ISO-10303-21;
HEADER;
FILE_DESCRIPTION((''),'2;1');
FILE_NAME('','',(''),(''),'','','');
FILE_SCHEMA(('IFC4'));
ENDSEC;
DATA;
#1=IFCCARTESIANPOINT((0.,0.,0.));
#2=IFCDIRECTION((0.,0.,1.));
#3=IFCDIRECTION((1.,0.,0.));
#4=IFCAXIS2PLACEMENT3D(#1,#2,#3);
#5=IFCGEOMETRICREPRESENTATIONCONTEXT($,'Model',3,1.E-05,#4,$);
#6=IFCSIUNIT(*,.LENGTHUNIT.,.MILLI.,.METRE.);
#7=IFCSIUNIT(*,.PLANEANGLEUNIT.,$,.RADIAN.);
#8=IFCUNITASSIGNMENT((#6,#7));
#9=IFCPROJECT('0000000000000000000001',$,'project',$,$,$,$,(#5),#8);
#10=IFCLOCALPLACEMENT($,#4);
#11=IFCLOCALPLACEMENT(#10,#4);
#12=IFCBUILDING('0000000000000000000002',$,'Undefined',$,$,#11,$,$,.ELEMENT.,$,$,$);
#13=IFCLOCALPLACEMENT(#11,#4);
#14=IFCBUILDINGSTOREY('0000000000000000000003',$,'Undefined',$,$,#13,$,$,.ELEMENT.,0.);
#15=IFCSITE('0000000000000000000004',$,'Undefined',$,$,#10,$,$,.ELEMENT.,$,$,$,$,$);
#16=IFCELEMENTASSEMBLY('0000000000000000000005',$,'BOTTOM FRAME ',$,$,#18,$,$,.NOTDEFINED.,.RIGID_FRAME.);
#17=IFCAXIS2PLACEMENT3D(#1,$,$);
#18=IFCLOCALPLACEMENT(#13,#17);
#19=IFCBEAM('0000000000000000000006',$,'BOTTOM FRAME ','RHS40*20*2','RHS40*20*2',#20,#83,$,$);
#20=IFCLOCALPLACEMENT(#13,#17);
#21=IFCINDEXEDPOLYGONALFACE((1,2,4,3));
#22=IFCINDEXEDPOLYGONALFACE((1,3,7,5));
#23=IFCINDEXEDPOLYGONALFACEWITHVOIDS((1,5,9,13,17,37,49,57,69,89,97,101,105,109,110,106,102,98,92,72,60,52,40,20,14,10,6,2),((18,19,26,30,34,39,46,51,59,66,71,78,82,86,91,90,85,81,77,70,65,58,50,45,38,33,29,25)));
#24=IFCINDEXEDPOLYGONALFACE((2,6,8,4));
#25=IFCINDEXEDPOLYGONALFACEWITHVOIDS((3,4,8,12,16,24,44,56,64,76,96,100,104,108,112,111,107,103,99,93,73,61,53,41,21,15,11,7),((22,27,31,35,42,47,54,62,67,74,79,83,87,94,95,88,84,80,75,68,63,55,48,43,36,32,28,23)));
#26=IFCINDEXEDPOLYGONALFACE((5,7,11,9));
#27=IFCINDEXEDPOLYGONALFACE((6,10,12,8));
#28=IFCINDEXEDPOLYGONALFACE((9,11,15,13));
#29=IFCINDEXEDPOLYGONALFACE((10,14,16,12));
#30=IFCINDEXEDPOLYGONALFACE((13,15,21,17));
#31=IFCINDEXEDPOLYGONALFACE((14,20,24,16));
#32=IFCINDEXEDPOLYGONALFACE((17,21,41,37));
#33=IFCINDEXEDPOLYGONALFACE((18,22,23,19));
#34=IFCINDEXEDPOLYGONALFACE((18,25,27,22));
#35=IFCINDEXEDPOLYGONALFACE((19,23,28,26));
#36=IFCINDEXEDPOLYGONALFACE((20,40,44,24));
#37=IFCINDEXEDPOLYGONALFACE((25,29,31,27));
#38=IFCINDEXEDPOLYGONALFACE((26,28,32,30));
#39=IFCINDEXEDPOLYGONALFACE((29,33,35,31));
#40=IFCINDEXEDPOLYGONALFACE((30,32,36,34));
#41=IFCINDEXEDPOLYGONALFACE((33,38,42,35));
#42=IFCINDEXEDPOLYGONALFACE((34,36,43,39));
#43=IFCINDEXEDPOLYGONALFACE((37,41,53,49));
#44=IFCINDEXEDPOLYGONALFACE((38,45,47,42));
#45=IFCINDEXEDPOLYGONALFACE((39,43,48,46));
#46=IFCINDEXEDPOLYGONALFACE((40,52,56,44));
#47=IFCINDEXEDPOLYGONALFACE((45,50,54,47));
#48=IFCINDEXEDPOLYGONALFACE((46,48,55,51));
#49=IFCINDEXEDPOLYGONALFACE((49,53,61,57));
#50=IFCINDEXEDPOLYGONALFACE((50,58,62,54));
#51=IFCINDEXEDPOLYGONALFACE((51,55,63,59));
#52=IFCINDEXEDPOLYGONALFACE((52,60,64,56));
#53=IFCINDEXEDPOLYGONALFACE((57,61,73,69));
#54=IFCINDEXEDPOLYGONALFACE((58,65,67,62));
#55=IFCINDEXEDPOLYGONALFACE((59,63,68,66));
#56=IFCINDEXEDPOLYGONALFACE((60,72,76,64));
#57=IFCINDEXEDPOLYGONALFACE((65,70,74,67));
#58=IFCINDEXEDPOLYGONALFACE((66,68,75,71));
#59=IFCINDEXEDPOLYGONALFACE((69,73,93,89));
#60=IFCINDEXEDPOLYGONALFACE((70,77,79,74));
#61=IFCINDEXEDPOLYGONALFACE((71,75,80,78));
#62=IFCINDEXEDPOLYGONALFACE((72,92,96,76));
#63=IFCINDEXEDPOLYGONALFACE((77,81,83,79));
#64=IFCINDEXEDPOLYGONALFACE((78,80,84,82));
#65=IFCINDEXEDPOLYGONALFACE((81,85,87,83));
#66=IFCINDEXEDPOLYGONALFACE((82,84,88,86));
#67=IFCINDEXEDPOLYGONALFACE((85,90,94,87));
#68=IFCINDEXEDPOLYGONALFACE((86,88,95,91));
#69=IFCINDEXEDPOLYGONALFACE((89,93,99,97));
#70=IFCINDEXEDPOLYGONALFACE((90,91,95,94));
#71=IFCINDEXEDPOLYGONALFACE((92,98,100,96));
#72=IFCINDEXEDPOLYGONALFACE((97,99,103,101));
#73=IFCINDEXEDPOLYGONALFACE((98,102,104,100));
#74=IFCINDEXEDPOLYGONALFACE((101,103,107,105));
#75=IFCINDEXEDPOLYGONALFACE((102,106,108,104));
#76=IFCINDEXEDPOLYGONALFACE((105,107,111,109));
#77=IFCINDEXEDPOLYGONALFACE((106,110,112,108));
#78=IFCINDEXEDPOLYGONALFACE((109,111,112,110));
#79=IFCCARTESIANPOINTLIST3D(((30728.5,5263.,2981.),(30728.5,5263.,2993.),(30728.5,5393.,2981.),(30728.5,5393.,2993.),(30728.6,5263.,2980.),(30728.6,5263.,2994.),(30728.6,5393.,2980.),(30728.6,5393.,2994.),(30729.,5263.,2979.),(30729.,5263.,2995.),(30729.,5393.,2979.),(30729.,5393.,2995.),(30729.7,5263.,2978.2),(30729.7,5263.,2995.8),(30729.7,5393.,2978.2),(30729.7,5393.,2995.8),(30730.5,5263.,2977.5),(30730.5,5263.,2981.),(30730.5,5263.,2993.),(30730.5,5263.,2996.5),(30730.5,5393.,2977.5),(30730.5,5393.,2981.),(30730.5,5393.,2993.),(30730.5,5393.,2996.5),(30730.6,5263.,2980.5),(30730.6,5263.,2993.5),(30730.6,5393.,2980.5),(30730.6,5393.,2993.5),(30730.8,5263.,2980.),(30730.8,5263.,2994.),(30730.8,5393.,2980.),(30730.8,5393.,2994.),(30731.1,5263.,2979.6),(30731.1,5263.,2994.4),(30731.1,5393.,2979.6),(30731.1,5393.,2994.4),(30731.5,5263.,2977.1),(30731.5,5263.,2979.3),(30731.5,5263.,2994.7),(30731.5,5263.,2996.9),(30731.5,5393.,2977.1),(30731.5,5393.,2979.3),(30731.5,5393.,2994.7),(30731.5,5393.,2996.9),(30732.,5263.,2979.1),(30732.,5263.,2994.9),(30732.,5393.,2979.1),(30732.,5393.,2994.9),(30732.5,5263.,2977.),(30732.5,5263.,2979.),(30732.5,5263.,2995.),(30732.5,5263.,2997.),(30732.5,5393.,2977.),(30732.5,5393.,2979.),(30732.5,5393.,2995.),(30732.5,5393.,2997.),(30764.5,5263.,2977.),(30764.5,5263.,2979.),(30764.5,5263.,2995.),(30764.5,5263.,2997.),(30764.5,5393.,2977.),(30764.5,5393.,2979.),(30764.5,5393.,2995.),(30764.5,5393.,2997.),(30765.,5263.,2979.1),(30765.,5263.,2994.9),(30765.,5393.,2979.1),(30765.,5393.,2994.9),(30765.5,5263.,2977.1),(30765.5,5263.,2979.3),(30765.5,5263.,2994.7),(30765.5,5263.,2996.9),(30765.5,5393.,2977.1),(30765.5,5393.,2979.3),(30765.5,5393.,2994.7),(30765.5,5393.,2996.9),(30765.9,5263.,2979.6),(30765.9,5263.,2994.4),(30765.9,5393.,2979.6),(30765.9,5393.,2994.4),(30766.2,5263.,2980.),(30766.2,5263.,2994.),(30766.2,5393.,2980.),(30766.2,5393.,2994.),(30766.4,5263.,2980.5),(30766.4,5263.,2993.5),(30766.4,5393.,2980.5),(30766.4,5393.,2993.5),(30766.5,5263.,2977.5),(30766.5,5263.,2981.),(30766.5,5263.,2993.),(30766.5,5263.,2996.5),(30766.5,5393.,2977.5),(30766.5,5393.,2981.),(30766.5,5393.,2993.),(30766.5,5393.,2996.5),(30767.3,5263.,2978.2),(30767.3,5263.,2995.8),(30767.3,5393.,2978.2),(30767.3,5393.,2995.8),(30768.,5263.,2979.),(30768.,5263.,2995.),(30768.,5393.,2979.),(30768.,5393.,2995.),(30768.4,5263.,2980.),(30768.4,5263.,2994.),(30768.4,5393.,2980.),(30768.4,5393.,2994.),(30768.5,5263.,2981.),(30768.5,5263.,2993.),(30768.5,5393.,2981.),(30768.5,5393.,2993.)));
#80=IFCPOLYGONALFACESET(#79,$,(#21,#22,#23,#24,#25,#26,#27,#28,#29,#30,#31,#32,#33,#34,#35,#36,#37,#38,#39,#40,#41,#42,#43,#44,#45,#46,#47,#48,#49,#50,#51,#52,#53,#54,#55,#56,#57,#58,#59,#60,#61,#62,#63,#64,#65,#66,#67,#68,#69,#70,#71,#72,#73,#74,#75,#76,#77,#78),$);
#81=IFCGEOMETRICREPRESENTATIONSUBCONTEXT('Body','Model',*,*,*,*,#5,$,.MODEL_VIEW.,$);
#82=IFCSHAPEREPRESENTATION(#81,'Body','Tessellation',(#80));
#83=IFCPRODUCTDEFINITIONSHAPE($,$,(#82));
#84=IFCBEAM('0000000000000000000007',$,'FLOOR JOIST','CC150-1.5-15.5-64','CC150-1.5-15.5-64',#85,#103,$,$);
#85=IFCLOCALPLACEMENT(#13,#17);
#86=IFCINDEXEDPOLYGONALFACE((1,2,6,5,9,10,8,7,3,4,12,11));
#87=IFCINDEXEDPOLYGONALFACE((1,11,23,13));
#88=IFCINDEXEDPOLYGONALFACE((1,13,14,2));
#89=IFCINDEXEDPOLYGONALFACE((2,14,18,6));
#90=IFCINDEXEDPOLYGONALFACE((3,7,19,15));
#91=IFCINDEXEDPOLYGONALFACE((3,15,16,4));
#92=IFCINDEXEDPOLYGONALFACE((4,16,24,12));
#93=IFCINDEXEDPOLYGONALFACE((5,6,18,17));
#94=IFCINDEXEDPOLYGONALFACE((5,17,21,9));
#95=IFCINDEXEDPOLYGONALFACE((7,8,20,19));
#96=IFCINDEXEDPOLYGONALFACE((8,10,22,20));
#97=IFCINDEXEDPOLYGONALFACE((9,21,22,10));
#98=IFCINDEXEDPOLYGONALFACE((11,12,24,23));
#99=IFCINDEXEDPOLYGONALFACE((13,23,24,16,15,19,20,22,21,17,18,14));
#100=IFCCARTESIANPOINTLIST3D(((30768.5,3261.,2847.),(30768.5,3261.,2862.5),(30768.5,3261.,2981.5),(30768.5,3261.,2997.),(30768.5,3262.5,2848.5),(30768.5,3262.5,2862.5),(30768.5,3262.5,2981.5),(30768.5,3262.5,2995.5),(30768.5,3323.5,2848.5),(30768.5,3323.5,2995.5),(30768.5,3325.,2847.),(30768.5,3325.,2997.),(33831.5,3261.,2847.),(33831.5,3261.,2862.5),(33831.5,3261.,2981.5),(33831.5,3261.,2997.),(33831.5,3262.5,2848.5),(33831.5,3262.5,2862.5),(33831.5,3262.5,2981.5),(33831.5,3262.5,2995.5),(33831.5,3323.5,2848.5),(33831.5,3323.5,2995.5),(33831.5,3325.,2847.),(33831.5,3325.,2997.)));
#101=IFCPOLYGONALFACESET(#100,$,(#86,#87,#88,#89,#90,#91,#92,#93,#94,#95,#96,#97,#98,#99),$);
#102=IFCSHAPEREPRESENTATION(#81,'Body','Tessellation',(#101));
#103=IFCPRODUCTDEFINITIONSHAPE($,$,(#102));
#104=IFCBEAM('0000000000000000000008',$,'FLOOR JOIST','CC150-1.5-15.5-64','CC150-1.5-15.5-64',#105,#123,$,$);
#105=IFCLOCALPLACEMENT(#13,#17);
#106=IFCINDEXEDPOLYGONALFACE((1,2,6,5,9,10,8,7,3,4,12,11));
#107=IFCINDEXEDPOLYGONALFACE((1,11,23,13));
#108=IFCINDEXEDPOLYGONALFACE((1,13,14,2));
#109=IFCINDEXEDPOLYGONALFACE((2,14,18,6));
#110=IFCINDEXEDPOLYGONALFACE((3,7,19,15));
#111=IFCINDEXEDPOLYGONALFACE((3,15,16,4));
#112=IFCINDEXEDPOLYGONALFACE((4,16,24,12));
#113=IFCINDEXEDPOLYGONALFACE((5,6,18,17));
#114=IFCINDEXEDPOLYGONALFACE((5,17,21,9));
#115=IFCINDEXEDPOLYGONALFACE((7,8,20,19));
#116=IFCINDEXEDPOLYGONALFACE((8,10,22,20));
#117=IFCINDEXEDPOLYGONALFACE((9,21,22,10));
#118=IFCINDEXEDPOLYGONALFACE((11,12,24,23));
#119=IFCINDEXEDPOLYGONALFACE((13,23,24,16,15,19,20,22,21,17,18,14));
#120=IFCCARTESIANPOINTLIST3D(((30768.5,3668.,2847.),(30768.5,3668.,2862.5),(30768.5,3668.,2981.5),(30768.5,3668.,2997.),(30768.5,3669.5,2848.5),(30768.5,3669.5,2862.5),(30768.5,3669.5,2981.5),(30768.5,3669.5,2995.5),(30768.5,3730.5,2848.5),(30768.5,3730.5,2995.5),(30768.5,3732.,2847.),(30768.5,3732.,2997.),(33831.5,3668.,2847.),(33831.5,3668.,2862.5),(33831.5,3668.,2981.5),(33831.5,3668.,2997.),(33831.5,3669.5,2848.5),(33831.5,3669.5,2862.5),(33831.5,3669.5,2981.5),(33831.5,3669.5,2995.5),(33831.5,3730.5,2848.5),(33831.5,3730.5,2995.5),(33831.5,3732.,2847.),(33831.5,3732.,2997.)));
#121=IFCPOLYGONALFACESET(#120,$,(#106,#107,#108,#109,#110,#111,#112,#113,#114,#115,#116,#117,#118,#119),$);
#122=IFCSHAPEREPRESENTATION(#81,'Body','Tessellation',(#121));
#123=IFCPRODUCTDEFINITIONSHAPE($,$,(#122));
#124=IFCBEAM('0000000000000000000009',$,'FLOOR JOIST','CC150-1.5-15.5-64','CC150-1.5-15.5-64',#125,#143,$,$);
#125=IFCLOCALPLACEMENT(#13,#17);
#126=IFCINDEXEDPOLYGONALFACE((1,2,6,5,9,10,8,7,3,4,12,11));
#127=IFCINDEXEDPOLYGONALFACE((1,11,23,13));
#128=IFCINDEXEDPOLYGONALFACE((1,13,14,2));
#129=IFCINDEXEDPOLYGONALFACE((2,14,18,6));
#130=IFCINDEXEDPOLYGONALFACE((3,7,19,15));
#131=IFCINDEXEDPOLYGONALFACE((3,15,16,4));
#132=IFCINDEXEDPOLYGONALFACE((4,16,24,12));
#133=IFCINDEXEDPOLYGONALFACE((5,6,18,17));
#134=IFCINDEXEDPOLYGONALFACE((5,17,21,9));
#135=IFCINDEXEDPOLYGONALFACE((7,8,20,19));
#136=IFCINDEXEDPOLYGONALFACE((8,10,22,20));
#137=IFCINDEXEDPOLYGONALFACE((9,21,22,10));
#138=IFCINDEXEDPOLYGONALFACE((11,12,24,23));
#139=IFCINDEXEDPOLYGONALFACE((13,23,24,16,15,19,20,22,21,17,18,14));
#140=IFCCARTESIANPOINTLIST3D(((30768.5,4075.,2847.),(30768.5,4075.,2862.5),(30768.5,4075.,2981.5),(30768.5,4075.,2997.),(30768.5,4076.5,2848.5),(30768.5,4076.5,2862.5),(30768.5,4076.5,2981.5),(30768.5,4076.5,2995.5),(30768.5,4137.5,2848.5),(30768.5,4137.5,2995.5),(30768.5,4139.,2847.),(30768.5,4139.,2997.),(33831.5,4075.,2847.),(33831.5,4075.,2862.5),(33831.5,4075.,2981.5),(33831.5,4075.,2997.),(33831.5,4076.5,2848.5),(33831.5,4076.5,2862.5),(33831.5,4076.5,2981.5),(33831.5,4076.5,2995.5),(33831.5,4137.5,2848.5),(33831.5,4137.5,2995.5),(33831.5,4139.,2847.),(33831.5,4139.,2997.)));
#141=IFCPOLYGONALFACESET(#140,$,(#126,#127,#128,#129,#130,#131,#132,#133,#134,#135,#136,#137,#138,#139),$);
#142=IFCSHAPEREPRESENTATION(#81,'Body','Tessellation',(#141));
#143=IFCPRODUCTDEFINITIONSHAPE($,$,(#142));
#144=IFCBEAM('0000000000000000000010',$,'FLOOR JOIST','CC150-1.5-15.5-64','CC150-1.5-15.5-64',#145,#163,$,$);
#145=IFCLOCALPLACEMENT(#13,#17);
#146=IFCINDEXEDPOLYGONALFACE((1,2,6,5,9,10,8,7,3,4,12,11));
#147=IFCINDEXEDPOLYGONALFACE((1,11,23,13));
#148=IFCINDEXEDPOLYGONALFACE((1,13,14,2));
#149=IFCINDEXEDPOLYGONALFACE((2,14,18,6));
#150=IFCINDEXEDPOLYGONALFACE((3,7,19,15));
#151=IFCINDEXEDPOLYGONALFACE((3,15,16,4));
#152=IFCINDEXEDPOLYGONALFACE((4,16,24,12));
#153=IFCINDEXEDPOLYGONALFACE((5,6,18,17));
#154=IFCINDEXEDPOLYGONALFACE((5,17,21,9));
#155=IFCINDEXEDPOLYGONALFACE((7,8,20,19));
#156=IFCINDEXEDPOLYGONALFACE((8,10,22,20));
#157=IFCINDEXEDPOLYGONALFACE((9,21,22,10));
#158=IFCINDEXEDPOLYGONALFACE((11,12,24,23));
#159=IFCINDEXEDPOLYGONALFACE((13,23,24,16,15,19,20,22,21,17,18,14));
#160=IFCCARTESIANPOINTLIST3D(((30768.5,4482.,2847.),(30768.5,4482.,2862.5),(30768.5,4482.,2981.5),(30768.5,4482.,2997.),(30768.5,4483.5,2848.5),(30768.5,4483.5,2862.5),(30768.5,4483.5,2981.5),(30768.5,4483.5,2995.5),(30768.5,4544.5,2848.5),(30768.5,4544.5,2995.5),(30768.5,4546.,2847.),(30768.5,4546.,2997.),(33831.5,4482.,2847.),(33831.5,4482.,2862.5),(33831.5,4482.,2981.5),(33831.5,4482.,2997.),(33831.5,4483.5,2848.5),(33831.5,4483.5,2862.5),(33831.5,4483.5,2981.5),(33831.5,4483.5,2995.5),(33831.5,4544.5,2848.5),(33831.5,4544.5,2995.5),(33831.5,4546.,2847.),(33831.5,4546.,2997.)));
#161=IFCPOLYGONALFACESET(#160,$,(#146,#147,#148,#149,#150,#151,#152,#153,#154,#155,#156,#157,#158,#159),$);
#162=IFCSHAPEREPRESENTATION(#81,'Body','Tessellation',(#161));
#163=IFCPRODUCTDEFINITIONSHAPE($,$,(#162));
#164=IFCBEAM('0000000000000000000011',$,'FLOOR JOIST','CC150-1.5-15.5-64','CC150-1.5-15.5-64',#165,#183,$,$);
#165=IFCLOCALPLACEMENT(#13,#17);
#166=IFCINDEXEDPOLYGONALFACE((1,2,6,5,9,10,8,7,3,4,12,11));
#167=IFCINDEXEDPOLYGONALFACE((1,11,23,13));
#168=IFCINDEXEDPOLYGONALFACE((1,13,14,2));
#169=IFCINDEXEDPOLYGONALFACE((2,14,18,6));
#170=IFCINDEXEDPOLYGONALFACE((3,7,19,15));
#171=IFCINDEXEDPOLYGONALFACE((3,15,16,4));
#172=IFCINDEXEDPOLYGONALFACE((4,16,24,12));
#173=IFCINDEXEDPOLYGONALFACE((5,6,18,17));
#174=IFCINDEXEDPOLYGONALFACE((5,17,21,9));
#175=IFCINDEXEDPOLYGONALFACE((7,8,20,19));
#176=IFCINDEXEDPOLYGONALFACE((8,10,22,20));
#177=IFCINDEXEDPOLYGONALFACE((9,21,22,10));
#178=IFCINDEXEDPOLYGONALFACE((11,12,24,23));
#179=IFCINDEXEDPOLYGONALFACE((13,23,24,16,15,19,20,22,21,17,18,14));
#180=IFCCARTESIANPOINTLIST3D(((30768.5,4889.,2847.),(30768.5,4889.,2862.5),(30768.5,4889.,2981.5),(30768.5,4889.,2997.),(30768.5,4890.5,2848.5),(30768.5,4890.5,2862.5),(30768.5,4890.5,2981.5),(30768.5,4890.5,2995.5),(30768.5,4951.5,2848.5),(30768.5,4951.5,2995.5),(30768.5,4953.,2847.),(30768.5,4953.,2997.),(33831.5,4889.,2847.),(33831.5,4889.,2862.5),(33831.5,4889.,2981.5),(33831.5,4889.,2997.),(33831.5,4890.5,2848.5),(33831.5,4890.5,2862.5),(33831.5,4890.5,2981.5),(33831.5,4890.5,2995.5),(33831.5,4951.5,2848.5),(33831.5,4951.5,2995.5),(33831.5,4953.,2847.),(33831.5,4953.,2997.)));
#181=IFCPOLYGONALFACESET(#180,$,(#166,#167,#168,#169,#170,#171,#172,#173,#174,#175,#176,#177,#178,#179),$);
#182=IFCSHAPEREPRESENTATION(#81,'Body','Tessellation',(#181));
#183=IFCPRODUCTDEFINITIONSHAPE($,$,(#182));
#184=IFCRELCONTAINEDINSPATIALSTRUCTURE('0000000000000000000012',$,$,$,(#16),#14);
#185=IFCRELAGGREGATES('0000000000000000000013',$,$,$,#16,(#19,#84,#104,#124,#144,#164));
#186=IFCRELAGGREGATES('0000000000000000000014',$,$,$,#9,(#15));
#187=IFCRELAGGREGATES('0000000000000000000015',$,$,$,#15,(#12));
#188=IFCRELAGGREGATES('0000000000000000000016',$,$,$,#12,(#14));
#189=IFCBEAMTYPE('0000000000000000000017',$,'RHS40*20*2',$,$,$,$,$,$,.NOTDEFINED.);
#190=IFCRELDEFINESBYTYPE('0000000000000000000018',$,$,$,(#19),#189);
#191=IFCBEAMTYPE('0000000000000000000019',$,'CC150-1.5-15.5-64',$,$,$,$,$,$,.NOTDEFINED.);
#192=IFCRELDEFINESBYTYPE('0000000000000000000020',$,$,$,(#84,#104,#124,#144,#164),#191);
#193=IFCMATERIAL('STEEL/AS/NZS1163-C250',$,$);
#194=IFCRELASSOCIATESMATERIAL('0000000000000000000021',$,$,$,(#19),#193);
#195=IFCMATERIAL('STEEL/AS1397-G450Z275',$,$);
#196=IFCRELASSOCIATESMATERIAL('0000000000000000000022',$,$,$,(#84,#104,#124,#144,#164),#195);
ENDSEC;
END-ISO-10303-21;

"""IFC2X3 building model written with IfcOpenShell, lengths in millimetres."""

from ifc_helpers import new_model, si_unit, frame, origin_with_axes, origin_2d_with_axis, place, context, subcontext, project, spatial, hollow_rectangle, c_section, extrude, material, type_object, element, aggregate, save


model = new_model("IFC2X3")

# Units and contexts
model_context = context("Model", 3, precision=1e-05, world=origin_with_axes())
body_context = subcontext(model_context, "Body", "Model", "MODEL_VIEW")
ifc_project = project(units=[si_unit("LENGTHUNIT", "METRE", prefix="MILLI"), si_unit("PLANEANGLEUNIT", "RADIAN")], contexts=[model_context])

# Site, building, storey
site_placement = place(None, origin_with_axes())
site = spatial("IfcSite", under=ifc_project, at=site_placement, Name="Undefined", CompositionType="ELEMENT")
building_placement = place(site_placement, origin_with_axes())
building = spatial("IfcBuilding", under=site, at=building_placement, Name="Undefined", CompositionType="ELEMENT")
storey_placement = place(building_placement, origin_with_axes())
storey = spatial("IfcBuildingStorey", under=building, at=storey_placement, Name="Undefined", CompositionType="ELEMENT", Elevation=0.0)

# Element assembly, beams
assembly_1_placement = place(storey_placement, origin_with_axes())
assembly_1 = element("IfcElementAssembly", 1, at=assembly_1_placement, inside=storey, Name="BOTTOM FRAME ", AssemblyPlace="NOTDEFINED", PredefinedType="RIGID_FRAME")
ifc_material_1 = material(Name="STEEL/AS/NZS1163-C250")
beam_type_1 = type_object("IfcBeamType", Name="RHS40*20*2", PredefinedType="NOTDEFINED")
beam_1_placement = place(assembly_1_placement, frame((30748.5, 5393.0, 2987.0), z_axis=(1.0, 0.0, 0.0), x_axis=(0.0, -1.0, 0.0)))
beam_1 = element("IfcBeam", 2, at=beam_1_placement, type_object=beam_type_1, material=ifc_material_1, Name="BOTTOM FRAME ", Description="RHS40*20*2", ObjectType="RHS40*20*2", context=body_context, shape_type="SweptSolid", body=[
    extrude(hollow_rectangle(XDim=20.0, YDim=40.0, WallThickness=2.0, InnerFilletRadius=2.0, OuterFilletRadius=4.0, at=origin_2d_with_axis()), frame((130.0, 0.0, 0.0), z_axis=(-1.0, 0.0, 0.0), x_axis=(0.0, -1.0, 0.0)), (0.0, 0.0, 1.0), 130.0),
])
ifc_material_2 = material(Name="STEEL/AS1397-G450Z275")
beam_type_2 = type_object("IfcBeamType", Name="CC150-1.5-15.5-64", PredefinedType="NOTDEFINED")
beam_2_placement = place(assembly_1_placement, frame((30768.5, 3293.0, 2922.0), z_axis=(0.0, 0.0, 1.0), x_axis=(1.0, 0.0, 0.0)))
beam_2 = element("IfcBeam", 3, at=beam_2_placement, type_object=beam_type_2, material=ifc_material_2, Name="FLOOR JOIST", Description="CC150-1.5-15.5-64", ObjectType="CC150-1.5-15.5-64", context=body_context, shape_type="SweptSolid", body=[
    extrude(c_section(Depth=150.0, Width=64.0, WallThickness=1.5, Girth=15.5, at=origin_2d_with_axis()), frame((3063.0, 0.0, 0.0), z_axis=(-1.0, 0.0, 0.0), x_axis=(0.0, -1.0, 0.0)), (0.0, 0.0, 1.0), 3063.0),
])
beam_3_placement = place(assembly_1_placement, frame((30768.5, 3700.0, 2922.0), z_axis=(0.0, 0.0, 1.0), x_axis=(1.0, 0.0, 0.0)))
beam_3 = element("IfcBeam", 4, at=beam_3_placement, type_object=beam_type_2, material=ifc_material_2, Name="FLOOR JOIST", Description="CC150-1.5-15.5-64", ObjectType="CC150-1.5-15.5-64", context=body_context, shape_type="SweptSolid", body=[
    extrude(c_section(Depth=150.0, Width=64.0, WallThickness=1.5, Girth=15.5, at=origin_2d_with_axis()), frame((3063.0, 0.0, 0.0), z_axis=(-1.0, 0.0, 0.0), x_axis=(0.0, -1.0, 0.0)), (0.0, 0.0, 1.0), 3063.0),
])
beam_4_placement = place(assembly_1_placement, frame((30768.5, 4107.0, 2922.0), z_axis=(0.0, 0.0, 1.0), x_axis=(1.0, 0.0, 0.0)))
beam_4 = element("IfcBeam", 5, at=beam_4_placement, type_object=beam_type_2, material=ifc_material_2, Name="FLOOR JOIST", Description="CC150-1.5-15.5-64", ObjectType="CC150-1.5-15.5-64", context=body_context, shape_type="SweptSolid", body=[
    extrude(c_section(Depth=150.0, Width=64.0, WallThickness=1.5, Girth=15.5, at=origin_2d_with_axis()), frame((3063.0, 0.0, 0.0), z_axis=(-1.0, 0.0, 0.0), x_axis=(0.0, -1.0, 0.0)), (0.0, 0.0, 1.0), 3063.0),
])
beam_5_placement = place(assembly_1_placement, frame((30768.5, 4514.0, 2922.0), z_axis=(0.0, 0.0, 1.0), x_axis=(1.0, 0.0, 0.0)))
beam_5 = element("IfcBeam", 6, at=beam_5_placement, type_object=beam_type_2, material=ifc_material_2, Name="FLOOR JOIST", Description="CC150-1.5-15.5-64", ObjectType="CC150-1.5-15.5-64", context=body_context, shape_type="SweptSolid", body=[
    extrude(c_section(Depth=150.0, Width=64.0, WallThickness=1.5, Girth=15.5, at=origin_2d_with_axis()), frame((3063.0, 0.0, 0.0), z_axis=(-1.0, 0.0, 0.0), x_axis=(0.0, -1.0, 0.0)), (0.0, 0.0, 1.0), 3063.0),
])
beam_6_placement = place(assembly_1_placement, frame((30768.5, 4921.0, 2922.0), z_axis=(0.0, 0.0, 1.0), x_axis=(1.0, 0.0, 0.0)))
beam_6 = element("IfcBeam", 7, at=beam_6_placement, type_object=beam_type_2, material=ifc_material_2, Name="FLOOR JOIST", Description="CC150-1.5-15.5-64", ObjectType="CC150-1.5-15.5-64", context=body_context, shape_type="SweptSolid", body=[
    extrude(c_section(Depth=150.0, Width=64.0, WallThickness=1.5, Girth=15.5, at=origin_2d_with_axis()), frame((3063.0, 0.0, 0.0), z_axis=(-1.0, 0.0, 0.0), x_axis=(0.0, -1.0, 0.0)), (0.0, 0.0, 1.0), 3063.0),
])
aggregate(assembly_1, [beam_1, beam_2, beam_3, beam_4, beam_5, beam_6])

save(model, "model.ifc")
